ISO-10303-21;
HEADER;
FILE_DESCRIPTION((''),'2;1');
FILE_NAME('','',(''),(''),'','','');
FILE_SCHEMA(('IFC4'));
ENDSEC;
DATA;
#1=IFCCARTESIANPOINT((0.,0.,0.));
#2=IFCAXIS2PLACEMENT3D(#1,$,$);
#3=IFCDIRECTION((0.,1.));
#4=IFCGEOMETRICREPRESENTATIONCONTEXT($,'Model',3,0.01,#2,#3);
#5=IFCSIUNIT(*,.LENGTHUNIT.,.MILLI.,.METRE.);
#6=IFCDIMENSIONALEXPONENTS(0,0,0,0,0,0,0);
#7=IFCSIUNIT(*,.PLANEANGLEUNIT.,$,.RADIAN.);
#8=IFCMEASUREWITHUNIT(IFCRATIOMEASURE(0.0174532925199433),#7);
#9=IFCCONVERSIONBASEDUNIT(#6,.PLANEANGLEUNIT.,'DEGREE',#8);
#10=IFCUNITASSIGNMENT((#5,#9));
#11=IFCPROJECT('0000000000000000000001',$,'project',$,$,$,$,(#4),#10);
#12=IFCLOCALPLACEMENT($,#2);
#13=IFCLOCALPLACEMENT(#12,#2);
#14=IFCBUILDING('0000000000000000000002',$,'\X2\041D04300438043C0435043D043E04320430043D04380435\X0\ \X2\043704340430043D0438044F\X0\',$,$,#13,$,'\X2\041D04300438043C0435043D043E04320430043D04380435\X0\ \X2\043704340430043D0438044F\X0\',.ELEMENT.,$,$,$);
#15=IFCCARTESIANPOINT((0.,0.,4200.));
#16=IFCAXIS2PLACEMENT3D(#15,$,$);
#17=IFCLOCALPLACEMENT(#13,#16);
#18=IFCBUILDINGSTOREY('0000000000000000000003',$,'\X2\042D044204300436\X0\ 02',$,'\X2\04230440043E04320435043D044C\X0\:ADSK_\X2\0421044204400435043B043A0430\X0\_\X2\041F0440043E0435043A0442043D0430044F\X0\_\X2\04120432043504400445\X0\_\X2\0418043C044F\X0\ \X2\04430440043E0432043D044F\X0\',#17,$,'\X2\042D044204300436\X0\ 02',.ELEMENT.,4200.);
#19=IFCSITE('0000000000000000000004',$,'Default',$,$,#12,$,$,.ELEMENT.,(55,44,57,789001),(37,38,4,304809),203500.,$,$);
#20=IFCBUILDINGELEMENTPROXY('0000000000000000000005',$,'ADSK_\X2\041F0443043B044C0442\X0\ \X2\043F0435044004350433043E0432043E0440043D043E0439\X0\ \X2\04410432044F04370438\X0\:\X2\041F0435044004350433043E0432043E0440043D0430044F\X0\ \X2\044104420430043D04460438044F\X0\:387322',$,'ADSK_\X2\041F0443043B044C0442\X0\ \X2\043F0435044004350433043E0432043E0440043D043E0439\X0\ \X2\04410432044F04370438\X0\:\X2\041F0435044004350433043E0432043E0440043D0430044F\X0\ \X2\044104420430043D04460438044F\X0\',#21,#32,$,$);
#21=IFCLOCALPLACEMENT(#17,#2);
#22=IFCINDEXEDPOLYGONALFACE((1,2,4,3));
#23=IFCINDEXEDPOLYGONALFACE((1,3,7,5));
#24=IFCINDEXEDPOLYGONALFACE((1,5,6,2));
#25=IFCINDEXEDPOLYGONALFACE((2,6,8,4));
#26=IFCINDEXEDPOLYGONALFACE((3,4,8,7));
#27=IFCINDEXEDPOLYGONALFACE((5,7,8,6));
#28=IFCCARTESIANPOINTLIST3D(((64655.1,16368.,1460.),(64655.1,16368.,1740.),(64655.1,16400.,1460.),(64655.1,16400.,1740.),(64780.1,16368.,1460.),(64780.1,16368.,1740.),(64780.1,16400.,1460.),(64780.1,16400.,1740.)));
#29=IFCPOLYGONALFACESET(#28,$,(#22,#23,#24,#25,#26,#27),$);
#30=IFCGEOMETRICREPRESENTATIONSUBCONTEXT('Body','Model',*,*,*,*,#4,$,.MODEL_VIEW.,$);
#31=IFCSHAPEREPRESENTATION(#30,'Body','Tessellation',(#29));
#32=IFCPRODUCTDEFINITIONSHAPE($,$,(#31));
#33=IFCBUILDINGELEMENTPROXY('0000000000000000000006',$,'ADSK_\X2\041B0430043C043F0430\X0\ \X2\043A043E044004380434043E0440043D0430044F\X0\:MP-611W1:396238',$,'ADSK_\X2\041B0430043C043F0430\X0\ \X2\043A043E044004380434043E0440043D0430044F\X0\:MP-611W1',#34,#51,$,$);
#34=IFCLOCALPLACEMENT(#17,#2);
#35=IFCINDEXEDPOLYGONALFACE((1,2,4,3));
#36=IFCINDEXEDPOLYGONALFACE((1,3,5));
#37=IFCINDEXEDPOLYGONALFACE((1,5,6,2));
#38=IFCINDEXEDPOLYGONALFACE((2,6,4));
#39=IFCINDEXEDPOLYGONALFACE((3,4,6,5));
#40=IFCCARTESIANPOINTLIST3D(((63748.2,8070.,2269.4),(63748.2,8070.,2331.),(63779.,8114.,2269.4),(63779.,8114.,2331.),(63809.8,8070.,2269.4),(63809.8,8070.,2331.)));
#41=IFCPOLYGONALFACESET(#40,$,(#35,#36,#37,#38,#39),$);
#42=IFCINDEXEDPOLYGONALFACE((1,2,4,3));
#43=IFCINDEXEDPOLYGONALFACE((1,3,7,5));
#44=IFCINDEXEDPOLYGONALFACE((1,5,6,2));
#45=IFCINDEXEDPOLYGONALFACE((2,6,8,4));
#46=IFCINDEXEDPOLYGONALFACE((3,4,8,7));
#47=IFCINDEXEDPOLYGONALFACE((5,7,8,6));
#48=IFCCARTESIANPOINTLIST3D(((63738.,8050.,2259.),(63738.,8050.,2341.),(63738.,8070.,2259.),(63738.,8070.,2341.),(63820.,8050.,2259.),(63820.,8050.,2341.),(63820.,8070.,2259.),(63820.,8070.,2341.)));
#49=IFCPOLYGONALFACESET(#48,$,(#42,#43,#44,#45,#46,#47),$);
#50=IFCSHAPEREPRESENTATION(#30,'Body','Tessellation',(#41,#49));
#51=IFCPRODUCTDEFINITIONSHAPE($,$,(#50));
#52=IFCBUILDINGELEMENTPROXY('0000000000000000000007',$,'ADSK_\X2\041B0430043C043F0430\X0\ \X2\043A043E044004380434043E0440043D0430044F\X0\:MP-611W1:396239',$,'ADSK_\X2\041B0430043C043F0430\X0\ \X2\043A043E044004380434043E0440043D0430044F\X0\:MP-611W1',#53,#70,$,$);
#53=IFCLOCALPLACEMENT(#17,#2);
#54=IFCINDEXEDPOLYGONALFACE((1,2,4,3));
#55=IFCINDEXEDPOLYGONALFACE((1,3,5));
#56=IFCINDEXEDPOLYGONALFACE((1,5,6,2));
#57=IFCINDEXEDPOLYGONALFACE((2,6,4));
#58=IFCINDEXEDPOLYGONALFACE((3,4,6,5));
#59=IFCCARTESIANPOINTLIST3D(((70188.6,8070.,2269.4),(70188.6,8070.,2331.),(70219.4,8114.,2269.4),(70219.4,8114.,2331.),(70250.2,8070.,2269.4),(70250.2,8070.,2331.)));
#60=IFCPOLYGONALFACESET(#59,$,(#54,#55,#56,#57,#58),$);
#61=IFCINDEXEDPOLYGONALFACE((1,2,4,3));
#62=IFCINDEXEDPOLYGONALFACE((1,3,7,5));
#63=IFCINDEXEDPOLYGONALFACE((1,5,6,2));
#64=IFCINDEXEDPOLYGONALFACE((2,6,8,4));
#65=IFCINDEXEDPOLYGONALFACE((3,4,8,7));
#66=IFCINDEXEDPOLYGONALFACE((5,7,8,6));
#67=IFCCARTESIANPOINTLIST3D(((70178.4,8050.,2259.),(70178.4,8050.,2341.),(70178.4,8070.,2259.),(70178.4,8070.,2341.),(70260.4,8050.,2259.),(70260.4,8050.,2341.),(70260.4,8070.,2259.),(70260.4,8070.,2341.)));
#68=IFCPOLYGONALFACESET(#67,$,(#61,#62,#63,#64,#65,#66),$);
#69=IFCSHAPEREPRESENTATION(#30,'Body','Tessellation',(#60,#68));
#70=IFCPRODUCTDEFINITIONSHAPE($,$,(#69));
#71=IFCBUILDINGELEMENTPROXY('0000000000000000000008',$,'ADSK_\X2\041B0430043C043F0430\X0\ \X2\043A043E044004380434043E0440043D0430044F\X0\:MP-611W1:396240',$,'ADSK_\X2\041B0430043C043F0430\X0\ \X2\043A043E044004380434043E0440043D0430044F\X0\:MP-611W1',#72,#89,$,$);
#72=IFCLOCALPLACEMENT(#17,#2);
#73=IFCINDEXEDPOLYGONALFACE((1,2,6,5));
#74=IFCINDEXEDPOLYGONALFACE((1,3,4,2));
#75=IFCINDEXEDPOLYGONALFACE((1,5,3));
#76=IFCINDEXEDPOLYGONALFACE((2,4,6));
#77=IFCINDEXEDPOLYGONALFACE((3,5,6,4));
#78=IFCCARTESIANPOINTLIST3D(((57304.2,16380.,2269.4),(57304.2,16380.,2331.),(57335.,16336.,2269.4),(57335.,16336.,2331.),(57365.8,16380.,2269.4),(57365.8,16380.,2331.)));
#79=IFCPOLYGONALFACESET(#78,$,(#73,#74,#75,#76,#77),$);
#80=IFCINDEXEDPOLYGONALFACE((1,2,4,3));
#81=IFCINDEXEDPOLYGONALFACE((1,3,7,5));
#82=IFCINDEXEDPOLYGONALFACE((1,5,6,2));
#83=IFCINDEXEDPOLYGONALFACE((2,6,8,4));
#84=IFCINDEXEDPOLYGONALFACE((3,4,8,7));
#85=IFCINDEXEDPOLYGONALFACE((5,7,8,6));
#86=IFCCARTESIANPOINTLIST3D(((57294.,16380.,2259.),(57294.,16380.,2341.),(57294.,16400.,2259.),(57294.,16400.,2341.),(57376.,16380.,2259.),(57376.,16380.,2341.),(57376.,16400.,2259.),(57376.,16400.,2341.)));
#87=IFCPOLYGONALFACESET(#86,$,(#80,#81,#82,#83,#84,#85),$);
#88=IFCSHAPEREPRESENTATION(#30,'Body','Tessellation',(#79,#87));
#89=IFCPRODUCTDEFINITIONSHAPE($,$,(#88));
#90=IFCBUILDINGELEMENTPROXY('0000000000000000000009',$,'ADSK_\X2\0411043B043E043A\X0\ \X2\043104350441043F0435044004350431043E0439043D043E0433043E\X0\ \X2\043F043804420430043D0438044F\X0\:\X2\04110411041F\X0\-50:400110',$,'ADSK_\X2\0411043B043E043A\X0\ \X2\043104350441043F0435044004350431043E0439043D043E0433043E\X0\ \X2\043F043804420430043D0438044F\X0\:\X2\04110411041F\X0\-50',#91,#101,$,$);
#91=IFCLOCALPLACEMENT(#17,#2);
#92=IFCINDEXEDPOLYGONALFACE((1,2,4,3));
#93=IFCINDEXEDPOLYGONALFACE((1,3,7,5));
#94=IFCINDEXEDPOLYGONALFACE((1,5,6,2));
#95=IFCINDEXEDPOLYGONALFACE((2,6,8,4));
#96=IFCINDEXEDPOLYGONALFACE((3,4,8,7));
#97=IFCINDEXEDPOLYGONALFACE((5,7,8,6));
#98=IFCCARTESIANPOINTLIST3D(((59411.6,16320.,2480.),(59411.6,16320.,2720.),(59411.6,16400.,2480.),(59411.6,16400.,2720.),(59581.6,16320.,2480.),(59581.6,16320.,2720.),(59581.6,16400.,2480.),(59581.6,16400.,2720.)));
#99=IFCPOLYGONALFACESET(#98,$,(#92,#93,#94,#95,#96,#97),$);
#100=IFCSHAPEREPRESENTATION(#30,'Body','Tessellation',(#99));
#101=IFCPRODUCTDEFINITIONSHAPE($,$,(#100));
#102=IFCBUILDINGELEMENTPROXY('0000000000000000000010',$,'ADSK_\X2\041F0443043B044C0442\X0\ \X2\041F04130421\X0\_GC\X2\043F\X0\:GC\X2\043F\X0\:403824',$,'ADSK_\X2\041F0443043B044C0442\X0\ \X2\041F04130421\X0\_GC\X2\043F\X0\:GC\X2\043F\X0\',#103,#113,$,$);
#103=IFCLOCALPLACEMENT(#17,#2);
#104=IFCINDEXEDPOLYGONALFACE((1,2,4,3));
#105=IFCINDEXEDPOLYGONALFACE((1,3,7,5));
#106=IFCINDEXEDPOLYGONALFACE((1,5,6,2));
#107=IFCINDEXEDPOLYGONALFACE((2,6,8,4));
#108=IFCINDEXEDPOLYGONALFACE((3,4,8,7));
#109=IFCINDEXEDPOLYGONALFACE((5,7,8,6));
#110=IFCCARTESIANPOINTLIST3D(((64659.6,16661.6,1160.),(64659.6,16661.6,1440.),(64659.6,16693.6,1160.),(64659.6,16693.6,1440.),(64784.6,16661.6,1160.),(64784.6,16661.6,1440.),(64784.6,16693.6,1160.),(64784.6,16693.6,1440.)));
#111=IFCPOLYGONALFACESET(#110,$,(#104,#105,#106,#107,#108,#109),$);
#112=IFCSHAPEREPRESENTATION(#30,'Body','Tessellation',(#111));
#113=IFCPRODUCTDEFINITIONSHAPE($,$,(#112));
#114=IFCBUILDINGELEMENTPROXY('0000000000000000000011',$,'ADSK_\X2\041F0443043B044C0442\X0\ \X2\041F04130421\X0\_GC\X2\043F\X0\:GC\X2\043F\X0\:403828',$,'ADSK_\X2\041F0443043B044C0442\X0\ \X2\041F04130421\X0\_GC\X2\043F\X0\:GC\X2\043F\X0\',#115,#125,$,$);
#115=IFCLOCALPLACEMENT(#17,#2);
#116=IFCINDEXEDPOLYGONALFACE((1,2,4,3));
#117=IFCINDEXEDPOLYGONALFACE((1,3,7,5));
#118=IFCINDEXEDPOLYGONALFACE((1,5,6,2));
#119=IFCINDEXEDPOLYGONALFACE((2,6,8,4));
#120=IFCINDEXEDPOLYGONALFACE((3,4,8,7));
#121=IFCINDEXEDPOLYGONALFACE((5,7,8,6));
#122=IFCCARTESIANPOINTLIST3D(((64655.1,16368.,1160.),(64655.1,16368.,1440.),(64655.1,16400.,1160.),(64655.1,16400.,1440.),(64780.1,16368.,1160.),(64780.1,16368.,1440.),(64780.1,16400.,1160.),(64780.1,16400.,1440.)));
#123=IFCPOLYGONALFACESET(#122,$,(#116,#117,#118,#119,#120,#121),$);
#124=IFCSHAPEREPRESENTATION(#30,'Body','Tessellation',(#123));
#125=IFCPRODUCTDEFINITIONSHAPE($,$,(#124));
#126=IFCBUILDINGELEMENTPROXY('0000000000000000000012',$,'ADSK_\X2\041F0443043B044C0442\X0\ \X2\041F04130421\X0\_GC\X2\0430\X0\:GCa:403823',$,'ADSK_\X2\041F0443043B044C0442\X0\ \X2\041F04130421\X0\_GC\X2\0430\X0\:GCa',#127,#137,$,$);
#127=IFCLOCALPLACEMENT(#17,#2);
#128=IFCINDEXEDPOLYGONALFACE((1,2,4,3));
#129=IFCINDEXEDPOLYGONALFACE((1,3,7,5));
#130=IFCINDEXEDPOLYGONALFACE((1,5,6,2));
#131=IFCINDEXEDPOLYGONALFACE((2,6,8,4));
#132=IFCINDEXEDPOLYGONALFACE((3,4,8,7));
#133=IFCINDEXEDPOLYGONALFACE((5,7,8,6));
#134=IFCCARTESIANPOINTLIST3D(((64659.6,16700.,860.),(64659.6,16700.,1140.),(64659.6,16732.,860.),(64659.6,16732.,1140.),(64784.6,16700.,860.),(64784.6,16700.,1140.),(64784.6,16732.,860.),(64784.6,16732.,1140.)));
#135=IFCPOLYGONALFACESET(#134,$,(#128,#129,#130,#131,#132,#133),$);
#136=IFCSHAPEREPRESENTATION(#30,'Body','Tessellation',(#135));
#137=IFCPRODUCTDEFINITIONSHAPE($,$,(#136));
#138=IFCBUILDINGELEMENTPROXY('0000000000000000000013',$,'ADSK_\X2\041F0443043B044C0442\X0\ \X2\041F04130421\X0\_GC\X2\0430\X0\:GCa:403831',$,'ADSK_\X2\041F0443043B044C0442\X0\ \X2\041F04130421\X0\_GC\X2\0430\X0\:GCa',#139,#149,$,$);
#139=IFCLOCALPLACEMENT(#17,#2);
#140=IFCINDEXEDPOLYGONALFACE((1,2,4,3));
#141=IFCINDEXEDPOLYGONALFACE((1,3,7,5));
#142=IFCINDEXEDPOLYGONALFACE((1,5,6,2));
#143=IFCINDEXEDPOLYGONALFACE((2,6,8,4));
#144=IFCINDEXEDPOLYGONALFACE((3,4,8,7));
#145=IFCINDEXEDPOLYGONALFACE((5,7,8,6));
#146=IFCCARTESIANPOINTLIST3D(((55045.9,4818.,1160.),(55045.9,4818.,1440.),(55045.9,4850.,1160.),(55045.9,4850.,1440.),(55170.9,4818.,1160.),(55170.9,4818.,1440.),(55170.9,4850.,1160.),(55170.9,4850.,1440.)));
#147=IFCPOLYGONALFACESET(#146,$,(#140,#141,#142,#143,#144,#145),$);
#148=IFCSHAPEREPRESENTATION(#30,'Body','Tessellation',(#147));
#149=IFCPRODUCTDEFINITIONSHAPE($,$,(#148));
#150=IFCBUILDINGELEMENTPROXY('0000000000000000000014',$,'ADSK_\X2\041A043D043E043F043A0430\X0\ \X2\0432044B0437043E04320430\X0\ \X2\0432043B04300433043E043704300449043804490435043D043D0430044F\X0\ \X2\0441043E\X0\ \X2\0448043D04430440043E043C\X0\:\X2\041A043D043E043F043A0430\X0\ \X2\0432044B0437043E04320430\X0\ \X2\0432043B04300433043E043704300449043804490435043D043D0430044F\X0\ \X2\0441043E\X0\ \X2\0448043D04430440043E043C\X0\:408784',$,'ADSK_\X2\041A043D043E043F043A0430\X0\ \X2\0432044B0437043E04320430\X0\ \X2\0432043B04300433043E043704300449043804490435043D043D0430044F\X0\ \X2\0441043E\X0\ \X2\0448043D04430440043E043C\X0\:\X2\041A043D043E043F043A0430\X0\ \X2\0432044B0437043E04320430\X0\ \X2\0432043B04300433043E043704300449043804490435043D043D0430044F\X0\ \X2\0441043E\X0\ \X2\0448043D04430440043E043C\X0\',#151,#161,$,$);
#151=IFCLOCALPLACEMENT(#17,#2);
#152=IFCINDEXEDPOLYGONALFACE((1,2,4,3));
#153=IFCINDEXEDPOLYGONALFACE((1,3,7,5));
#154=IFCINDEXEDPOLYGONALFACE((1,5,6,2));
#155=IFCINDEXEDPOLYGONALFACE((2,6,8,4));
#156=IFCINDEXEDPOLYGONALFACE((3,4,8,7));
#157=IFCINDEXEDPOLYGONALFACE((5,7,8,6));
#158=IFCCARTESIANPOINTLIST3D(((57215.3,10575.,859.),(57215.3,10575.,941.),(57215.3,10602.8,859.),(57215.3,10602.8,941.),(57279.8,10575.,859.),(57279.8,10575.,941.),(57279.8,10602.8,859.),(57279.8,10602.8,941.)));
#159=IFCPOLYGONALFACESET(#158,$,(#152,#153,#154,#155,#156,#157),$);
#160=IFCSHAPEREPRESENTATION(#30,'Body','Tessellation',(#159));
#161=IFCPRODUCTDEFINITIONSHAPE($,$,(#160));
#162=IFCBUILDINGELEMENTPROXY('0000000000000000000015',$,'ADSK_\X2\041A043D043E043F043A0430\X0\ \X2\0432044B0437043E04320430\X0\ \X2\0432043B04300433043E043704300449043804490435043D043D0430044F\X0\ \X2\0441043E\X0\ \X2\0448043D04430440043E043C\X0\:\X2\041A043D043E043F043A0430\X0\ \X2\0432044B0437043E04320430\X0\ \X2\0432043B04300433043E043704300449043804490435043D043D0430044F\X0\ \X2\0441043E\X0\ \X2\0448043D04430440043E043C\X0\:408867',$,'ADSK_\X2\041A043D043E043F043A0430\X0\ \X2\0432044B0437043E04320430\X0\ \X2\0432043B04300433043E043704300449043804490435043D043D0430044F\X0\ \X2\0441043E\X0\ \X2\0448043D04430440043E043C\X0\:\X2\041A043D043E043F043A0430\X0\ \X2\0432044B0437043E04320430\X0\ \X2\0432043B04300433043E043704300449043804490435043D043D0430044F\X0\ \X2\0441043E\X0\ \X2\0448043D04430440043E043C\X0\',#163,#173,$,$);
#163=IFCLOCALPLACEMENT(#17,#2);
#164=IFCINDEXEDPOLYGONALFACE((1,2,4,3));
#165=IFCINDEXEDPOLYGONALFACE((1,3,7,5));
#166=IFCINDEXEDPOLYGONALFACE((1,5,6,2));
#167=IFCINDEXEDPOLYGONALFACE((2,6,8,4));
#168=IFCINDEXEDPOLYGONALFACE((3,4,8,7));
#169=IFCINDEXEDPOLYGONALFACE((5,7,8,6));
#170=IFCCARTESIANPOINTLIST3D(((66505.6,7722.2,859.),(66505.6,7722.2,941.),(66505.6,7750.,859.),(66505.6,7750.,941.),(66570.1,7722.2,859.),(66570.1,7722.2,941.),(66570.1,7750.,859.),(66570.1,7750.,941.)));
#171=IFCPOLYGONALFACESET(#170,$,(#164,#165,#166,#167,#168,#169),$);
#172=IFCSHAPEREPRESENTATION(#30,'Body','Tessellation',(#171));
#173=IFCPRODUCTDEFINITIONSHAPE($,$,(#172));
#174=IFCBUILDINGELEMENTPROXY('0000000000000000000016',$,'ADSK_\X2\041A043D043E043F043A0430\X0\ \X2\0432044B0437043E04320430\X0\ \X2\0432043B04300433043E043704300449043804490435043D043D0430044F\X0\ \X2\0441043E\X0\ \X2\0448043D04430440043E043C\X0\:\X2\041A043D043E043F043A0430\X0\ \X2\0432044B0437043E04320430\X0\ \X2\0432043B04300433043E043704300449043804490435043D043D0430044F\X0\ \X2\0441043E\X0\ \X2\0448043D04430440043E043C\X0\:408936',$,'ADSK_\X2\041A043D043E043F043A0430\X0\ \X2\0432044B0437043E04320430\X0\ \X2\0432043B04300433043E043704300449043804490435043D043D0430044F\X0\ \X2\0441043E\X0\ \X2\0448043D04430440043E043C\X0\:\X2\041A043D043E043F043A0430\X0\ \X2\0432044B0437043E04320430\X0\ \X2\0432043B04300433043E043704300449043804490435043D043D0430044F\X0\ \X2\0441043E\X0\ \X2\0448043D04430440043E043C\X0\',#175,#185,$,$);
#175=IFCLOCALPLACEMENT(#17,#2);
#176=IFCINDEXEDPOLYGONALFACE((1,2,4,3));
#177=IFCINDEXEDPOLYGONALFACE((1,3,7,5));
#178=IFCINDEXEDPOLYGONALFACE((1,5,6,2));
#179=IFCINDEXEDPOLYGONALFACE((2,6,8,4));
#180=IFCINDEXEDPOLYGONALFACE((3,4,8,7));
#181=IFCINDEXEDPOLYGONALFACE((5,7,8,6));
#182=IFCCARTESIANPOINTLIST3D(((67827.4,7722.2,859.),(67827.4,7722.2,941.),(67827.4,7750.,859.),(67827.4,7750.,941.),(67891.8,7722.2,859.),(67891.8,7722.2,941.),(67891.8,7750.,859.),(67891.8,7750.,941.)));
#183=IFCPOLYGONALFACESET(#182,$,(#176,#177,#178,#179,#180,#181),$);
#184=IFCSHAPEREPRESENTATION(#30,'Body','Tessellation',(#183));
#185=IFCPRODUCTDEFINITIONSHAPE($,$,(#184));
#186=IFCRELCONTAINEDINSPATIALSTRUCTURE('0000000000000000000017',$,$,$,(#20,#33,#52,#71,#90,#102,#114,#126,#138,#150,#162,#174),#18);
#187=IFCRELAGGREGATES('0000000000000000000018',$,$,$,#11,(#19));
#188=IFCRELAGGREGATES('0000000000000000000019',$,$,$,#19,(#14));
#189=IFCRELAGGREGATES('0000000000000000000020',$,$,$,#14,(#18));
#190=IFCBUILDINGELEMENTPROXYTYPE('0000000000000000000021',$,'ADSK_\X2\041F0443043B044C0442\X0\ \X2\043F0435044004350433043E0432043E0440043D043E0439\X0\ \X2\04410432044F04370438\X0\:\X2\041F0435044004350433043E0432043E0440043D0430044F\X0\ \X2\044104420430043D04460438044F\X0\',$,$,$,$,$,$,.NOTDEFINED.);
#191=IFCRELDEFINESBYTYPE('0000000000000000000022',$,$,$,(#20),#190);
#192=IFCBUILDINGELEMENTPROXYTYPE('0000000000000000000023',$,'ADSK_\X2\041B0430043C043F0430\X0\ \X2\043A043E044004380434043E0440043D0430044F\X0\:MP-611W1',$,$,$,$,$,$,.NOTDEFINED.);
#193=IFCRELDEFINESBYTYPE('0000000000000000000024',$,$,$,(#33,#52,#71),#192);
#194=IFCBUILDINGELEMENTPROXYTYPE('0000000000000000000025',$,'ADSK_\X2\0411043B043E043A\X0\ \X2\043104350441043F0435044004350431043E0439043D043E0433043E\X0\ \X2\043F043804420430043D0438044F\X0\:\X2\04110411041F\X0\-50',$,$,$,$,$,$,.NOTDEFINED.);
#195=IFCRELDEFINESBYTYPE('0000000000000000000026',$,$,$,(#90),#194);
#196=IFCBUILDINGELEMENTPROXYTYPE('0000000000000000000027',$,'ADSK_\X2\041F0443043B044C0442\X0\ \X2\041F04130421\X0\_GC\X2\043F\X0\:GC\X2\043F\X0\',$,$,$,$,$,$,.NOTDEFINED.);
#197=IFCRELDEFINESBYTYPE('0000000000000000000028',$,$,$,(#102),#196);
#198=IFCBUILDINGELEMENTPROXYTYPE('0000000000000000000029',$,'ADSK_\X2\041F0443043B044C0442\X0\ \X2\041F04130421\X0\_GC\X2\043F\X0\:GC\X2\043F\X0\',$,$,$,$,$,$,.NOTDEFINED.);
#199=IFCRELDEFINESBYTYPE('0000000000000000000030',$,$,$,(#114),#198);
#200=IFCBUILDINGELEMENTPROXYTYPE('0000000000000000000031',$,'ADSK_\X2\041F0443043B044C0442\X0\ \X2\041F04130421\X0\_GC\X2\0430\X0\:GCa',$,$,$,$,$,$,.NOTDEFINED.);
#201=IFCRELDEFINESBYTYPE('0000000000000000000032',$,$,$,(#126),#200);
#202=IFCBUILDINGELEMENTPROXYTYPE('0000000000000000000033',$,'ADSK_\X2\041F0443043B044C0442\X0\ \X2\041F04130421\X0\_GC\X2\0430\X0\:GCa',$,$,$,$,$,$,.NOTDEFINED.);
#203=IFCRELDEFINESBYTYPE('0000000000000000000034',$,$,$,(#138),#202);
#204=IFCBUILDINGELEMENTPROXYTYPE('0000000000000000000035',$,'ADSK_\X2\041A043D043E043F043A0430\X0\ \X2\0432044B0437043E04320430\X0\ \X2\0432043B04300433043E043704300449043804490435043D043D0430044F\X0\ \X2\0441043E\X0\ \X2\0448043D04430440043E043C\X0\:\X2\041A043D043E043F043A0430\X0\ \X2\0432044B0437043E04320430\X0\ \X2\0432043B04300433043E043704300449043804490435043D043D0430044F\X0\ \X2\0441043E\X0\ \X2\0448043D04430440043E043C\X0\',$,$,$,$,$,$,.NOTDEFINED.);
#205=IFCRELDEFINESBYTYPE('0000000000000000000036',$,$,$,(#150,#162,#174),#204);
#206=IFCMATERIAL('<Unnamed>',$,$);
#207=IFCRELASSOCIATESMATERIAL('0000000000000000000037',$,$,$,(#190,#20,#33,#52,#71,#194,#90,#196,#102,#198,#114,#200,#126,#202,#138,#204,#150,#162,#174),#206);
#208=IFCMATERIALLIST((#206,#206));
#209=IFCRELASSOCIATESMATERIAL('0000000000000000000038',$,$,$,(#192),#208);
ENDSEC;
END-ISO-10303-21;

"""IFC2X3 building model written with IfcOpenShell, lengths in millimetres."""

from ifc_helpers import new_model, entity, si_unit, converted_unit, direction, frame, origin, origin_2d_with_axis, place, context, subcontext, project, spatial, polyline, rectangle, outline, extrude, source, transform, mapped, material, material_list, type_object, type_shapes, element, save


model = new_model("IFC2X3")

# Units and contexts
model_context = context("Model", 3, precision=0.01, world=origin(), true_north=direction((0.0, 1.0)))
body_context = subcontext(model_context, "Body", "Model", "MODEL_VIEW")
ifc_project = project(units=[si_unit("LENGTHUNIT", "METRE", prefix="MILLI"), converted_unit("PLANEANGLEUNIT", "DEGREE", entity("IfcRatioMeasure", 0.0174532925199433), si_unit("PLANEANGLEUNIT", "RADIAN"), dimensions=[0, 0, 0, 0, 0, 0, 0])], contexts=[model_context])

# Site, building, storey
site_placement = place(None, origin())
site = spatial("IfcSite", under=ifc_project, at=site_placement, Name="Default", CompositionType="ELEMENT", RefLatitude=(55, 44, 57, 789001), RefLongitude=(37, 38, 4, 304809), RefElevation=203500.0)
building_placement = place(site_placement, origin())
building = spatial("IfcBuilding", under=site, at=building_placement, Name="Наименование здания", LongName="Наименование здания", CompositionType="ELEMENT")
storey_placement = place(building_placement, frame((0.0, 0.0, 4200.0)))
storey = spatial("IfcBuildingStorey", under=building, at=storey_placement, Name="Этаж 02", ObjectType="Уровень:ADSK_Стрелка_Проектная_Вверх_Имя уровня", LongName="Этаж 02", CompositionType="ELEMENT", Elevation=4200.0)

# Building element proxies
ifc_material = material(Name="<Unnamed>")
building_element_proxy_type_1 = type_object("IfcBuildingElementProxyType", Name="ADSK_Пульт переговорной связи:Переговорная станция", PredefinedType="NOTDEFINED", material=ifc_material)
shared_shape_1 = source(origin(), body_context, "Body", "SweptSolid", [
    extrude(rectangle(XDim=125.0, YDim=32.0, at=origin_2d_with_axis()), frame((0.0, 16.0, -140.0), z_axis=(0.0, 0.0, 1.0), x_axis=(-1.0, 0.0, 0.0)), (0.0, 0.0, 1.0), 280.0),
])
type_shapes(building_element_proxy_type_1, [shared_shape_1])
proxy_1_placement = place(storey_placement, frame((64717.6, 16368.0, 1600.0)))
element("IfcBuildingElementProxy", 1, at=proxy_1_placement, inside=storey, type_object=building_element_proxy_type_1, material=ifc_material, Name="ADSK_Пульт переговорной связи:Переговорная станция:387322", ObjectType="ADSK_Пульт переговорной связи:Переговорная станция", context=body_context, shape_type="MappedRepresentation", body=[
    mapped(shared_shape_1, transform((0.0, 0.0, 0.0), scale=1.0)),
])
ifc_material_list = material_list([ifc_material, ifc_material])
building_element_proxy_type_2 = type_object("IfcBuildingElementProxyType", Name="ADSK_Лампа коридорная:MP-611W1", PredefinedType="NOTDEFINED", material=ifc_material_list)
shared_shape_2 = source(origin(), body_context, "Body", "SweptSolid", [
    extrude(outline(polyline([(-30.8, -14.7), (30.8, -14.7), (0.0, 29.3), (-30.8, -14.7)])), frame((0.0, -2.7, -30.6), z_axis=(0.0, 0.0, 1.0), x_axis=(-1.0, 0.0, 0.0)), (0.0, 0.0, 1.0), 61.6),
    extrude(rectangle(XDim=82.0, YDim=20.0, at=origin_2d_with_axis()), frame((0.0, 22.0, -41.0), z_axis=(0.0, 0.0, 1.0), x_axis=(-1.0, 0.0, 0.0)), (0.0, 0.0, 1.0), 82.0),
])
type_shapes(building_element_proxy_type_2, [shared_shape_2])
for number, where, z_axis, x_axis, name in (
    (2, (63779.0, 8082.0, 2300.0), (0.0, 0.0, 1.0), (-1.0, 0.0, 0.0), "ADSK_Лампа коридорная:MP-611W1:396238"),
    (3, (70219.4, 8082.0, 2300.0), (0.0, 0.0, 1.0), (-1.0, 0.0, 0.0), "ADSK_Лампа коридорная:MP-611W1:396239"),
):
    element("IfcBuildingElementProxy", number, at=place(storey_placement, frame(where, z_axis=z_axis, x_axis=x_axis)), inside=storey, type_object=building_element_proxy_type_2, material=ifc_material, Name=name, ObjectType="ADSK_Лампа коридорная:MP-611W1", context=body_context, shape_type="MappedRepresentation", body=[
        mapped(shared_shape_2, transform((0.0, 0.0, 0.0), scale=1.0)),
    ])
proxy_2_placement = place(storey_placement, frame((57335.0, 16368.0, 2300.0)))
element("IfcBuildingElementProxy", 4, at=proxy_2_placement, inside=storey, type_object=building_element_proxy_type_2, material=ifc_material, Name="ADSK_Лампа коридорная:MP-611W1:396240", ObjectType="ADSK_Лампа коридорная:MP-611W1", context=body_context, shape_type="MappedRepresentation", body=[
    mapped(shared_shape_2, transform((0.0, 0.0, 0.0), scale=1.0)),
])
building_element_proxy_type_3 = type_object("IfcBuildingElementProxyType", Name="ADSK_Блок бесперебойного питания:ББП-50", PredefinedType="NOTDEFINED", material=ifc_material)
shared_shape_3 = source(origin(), body_context, "Body", "SweptSolid", [
    extrude(rectangle(XDim=170.0, YDim=80.0, at=origin_2d_with_axis()), frame((0.0, -8.0, -120.0), z_axis=(0.0, 0.0, 1.0), x_axis=(-1.0, 0.0, 0.0)), (0.0, 0.0, 1.0), 240.0),
])
type_shapes(building_element_proxy_type_3, [shared_shape_3])
proxy_3_placement = place(storey_placement, frame((59496.6, 16368.0, 2600.0)))
element("IfcBuildingElementProxy", 5, at=proxy_3_placement, inside=storey, type_object=building_element_proxy_type_3, material=ifc_material, Name="ADSK_Блок бесперебойного питания:ББП-50:400110", ObjectType="ADSK_Блок бесперебойного питания:ББП-50", context=body_context, shape_type="MappedRepresentation", body=[
    mapped(shared_shape_3, transform((0.0, 0.0, 0.0), scale=1.0)),
])
building_element_proxy_type_4 = type_object("IfcBuildingElementProxyType", Name="ADSK_Пульт ПГС_GCп:GCп", PredefinedType="NOTDEFINED", material=ifc_material)
shared_shape_4 = source(origin(), body_context, "Body", "SweptSolid", [
    extrude(rectangle(XDim=125.0, YDim=32.0, at=origin_2d_with_axis()), frame((0.0, 16.0, -140.0), z_axis=(0.0, 0.0, 1.0), x_axis=(-1.0, 0.0, 0.0)), (0.0, 0.0, 1.0), 280.0),
])
type_shapes(building_element_proxy_type_4, [shared_shape_4])
proxy_4_placement = place(storey_placement, frame((64722.1, 16693.6, 1300.0), z_axis=(0.0, 0.0, 1.0), x_axis=(-1.0, 0.0, 0.0)))
element("IfcBuildingElementProxy", 6, at=proxy_4_placement, inside=storey, type_object=building_element_proxy_type_4, material=ifc_material, Name="ADSK_Пульт ПГС_GCп:GCп:403824", ObjectType="ADSK_Пульт ПГС_GCп:GCп", context=body_context, shape_type="MappedRepresentation", body=[
    mapped(shared_shape_4, transform((0.0, 0.0, 0.0), scale=1.0)),
])
building_element_proxy_type_5 = type_object("IfcBuildingElementProxyType", Name="ADSK_Пульт ПГС_GCп:GCп", PredefinedType="NOTDEFINED", material=ifc_material)
type_shapes(building_element_proxy_type_5, [shared_shape_4])
proxy_5_placement = place(storey_placement, frame((64717.6, 16368.0, 1300.0)))
element("IfcBuildingElementProxy", 7, at=proxy_5_placement, inside=storey, type_object=building_element_proxy_type_5, material=ifc_material, Name="ADSK_Пульт ПГС_GCп:GCп:403828", ObjectType="ADSK_Пульт ПГС_GCп:GCп", context=body_context, shape_type="MappedRepresentation", body=[
    mapped(shared_shape_4, transform((0.0, 0.0, 0.0), scale=1.0)),
])
building_element_proxy_type_6 = type_object("IfcBuildingElementProxyType", Name="ADSK_Пульт ПГС_GCа:GCa", PredefinedType="NOTDEFINED", material=ifc_material)
shared_shape_5 = source(origin(), body_context, "Body", "SweptSolid", [
    extrude(rectangle(XDim=125.0, YDim=32.0, at=origin_2d_with_axis()), frame((0.0, 16.0, -140.0), z_axis=(0.0, 0.0, 1.0), x_axis=(-1.0, 0.0, 0.0)), (0.0, 0.0, 1.0), 280.0),
])
type_shapes(building_element_proxy_type_6, [shared_shape_5])
proxy_6_placement = place(storey_placement, frame((64722.1, 16732.0, 1000.0), z_axis=(0.0, 0.0, 1.0), x_axis=(-1.0, 0.0, 0.0)))
element("IfcBuildingElementProxy", 8, at=proxy_6_placement, inside=storey, type_object=building_element_proxy_type_6, material=ifc_material, Name="ADSK_Пульт ПГС_GCа:GCa:403823", ObjectType="ADSK_Пульт ПГС_GCа:GCa", context=body_context, shape_type="MappedRepresentation", body=[
    mapped(shared_shape_5, transform((0.0, 0.0, 0.0), scale=1.0)),
])
building_element_proxy_type_7 = type_object("IfcBuildingElementProxyType", Name="ADSK_Пульт ПГС_GCа:GCa", PredefinedType="NOTDEFINED", material=ifc_material)
type_shapes(building_element_proxy_type_7, [shared_shape_5])
proxy_7_placement = place(storey_placement, frame((55108.4, 4818.0, 1300.0)))
element("IfcBuildingElementProxy", 9, at=proxy_7_placement, inside=storey, type_object=building_element_proxy_type_7, material=ifc_material, Name="ADSK_Пульт ПГС_GCа:GCa:403831", ObjectType="ADSK_Пульт ПГС_GCа:GCa", context=body_context, shape_type="MappedRepresentation", body=[
    mapped(shared_shape_5, transform((0.0, 0.0, 0.0), scale=1.0)),
])
building_element_proxy_type_8 = type_object("IfcBuildingElementProxyType", Name="ADSK_Кнопка вызова влагозащищенная со шнуром:Кнопка вызова влагозащищенная со шнуром", PredefinedType="NOTDEFINED", material=ifc_material)
shared_shape_6 = source(origin(), body_context, "Body", "SweptSolid", [
    extrude(rectangle(XDim=64.5, YDim=27.8, at=origin_2d_with_axis()), frame((32.2, 13.9, 0.0), z_axis=(0.0, 0.0, 1.0), x_axis=(-1.0, 0.0, 0.0)), (0.0, 0.0, 1.0), 82.0),
])
type_shapes(building_element_proxy_type_8, [shared_shape_6])
proxy_8_placement = place(storey_placement, frame((57279.8, 10602.8, 859.0), z_axis=(0.0, 0.0, 1.0), x_axis=(-1.0, 0.0, 0.0)))
element("IfcBuildingElementProxy", 10, at=proxy_8_placement, inside=storey, type_object=building_element_proxy_type_8, material=ifc_material, Name="ADSK_Кнопка вызова влагозащищенная со шнуром:Кнопка вызова влагозащищенная со шнуром:408784", ObjectType="ADSK_Кнопка вызова влагозащищенная со шнуром:Кнопка вызова влагозащищенная со шнуром", context=body_context, shape_type="MappedRepresentation", body=[
    mapped(shared_shape_6, transform((0.0, 0.0, 0.0), scale=1.0)),
])
for number, where, name in (
    (11, (66505.6, 7722.2, 859.0), "ADSK_Кнопка вызова влагозащищенная со шнуром:Кнопка вызова влагозащищенная со шнуром:408867"),
    (12, (67827.4, 7722.2, 859.0), "ADSK_Кнопка вызова влагозащищенная со шнуром:Кнопка вызова влагозащищенная со шнуром:408936"),
):
    element("IfcBuildingElementProxy", number, at=place(storey_placement, frame(where)), inside=storey, type_object=building_element_proxy_type_8, material=ifc_material, Name=name, ObjectType="ADSK_Кнопка вызова влагозащищенная со шнуром:Кнопка вызова влагозащищенная со шнуром", context=body_context, shape_type="MappedRepresentation", body=[
        mapped(shared_shape_6, transform((0.0, 0.0, 0.0), scale=1.0)),
    ])

save(model, "model.ifc")
